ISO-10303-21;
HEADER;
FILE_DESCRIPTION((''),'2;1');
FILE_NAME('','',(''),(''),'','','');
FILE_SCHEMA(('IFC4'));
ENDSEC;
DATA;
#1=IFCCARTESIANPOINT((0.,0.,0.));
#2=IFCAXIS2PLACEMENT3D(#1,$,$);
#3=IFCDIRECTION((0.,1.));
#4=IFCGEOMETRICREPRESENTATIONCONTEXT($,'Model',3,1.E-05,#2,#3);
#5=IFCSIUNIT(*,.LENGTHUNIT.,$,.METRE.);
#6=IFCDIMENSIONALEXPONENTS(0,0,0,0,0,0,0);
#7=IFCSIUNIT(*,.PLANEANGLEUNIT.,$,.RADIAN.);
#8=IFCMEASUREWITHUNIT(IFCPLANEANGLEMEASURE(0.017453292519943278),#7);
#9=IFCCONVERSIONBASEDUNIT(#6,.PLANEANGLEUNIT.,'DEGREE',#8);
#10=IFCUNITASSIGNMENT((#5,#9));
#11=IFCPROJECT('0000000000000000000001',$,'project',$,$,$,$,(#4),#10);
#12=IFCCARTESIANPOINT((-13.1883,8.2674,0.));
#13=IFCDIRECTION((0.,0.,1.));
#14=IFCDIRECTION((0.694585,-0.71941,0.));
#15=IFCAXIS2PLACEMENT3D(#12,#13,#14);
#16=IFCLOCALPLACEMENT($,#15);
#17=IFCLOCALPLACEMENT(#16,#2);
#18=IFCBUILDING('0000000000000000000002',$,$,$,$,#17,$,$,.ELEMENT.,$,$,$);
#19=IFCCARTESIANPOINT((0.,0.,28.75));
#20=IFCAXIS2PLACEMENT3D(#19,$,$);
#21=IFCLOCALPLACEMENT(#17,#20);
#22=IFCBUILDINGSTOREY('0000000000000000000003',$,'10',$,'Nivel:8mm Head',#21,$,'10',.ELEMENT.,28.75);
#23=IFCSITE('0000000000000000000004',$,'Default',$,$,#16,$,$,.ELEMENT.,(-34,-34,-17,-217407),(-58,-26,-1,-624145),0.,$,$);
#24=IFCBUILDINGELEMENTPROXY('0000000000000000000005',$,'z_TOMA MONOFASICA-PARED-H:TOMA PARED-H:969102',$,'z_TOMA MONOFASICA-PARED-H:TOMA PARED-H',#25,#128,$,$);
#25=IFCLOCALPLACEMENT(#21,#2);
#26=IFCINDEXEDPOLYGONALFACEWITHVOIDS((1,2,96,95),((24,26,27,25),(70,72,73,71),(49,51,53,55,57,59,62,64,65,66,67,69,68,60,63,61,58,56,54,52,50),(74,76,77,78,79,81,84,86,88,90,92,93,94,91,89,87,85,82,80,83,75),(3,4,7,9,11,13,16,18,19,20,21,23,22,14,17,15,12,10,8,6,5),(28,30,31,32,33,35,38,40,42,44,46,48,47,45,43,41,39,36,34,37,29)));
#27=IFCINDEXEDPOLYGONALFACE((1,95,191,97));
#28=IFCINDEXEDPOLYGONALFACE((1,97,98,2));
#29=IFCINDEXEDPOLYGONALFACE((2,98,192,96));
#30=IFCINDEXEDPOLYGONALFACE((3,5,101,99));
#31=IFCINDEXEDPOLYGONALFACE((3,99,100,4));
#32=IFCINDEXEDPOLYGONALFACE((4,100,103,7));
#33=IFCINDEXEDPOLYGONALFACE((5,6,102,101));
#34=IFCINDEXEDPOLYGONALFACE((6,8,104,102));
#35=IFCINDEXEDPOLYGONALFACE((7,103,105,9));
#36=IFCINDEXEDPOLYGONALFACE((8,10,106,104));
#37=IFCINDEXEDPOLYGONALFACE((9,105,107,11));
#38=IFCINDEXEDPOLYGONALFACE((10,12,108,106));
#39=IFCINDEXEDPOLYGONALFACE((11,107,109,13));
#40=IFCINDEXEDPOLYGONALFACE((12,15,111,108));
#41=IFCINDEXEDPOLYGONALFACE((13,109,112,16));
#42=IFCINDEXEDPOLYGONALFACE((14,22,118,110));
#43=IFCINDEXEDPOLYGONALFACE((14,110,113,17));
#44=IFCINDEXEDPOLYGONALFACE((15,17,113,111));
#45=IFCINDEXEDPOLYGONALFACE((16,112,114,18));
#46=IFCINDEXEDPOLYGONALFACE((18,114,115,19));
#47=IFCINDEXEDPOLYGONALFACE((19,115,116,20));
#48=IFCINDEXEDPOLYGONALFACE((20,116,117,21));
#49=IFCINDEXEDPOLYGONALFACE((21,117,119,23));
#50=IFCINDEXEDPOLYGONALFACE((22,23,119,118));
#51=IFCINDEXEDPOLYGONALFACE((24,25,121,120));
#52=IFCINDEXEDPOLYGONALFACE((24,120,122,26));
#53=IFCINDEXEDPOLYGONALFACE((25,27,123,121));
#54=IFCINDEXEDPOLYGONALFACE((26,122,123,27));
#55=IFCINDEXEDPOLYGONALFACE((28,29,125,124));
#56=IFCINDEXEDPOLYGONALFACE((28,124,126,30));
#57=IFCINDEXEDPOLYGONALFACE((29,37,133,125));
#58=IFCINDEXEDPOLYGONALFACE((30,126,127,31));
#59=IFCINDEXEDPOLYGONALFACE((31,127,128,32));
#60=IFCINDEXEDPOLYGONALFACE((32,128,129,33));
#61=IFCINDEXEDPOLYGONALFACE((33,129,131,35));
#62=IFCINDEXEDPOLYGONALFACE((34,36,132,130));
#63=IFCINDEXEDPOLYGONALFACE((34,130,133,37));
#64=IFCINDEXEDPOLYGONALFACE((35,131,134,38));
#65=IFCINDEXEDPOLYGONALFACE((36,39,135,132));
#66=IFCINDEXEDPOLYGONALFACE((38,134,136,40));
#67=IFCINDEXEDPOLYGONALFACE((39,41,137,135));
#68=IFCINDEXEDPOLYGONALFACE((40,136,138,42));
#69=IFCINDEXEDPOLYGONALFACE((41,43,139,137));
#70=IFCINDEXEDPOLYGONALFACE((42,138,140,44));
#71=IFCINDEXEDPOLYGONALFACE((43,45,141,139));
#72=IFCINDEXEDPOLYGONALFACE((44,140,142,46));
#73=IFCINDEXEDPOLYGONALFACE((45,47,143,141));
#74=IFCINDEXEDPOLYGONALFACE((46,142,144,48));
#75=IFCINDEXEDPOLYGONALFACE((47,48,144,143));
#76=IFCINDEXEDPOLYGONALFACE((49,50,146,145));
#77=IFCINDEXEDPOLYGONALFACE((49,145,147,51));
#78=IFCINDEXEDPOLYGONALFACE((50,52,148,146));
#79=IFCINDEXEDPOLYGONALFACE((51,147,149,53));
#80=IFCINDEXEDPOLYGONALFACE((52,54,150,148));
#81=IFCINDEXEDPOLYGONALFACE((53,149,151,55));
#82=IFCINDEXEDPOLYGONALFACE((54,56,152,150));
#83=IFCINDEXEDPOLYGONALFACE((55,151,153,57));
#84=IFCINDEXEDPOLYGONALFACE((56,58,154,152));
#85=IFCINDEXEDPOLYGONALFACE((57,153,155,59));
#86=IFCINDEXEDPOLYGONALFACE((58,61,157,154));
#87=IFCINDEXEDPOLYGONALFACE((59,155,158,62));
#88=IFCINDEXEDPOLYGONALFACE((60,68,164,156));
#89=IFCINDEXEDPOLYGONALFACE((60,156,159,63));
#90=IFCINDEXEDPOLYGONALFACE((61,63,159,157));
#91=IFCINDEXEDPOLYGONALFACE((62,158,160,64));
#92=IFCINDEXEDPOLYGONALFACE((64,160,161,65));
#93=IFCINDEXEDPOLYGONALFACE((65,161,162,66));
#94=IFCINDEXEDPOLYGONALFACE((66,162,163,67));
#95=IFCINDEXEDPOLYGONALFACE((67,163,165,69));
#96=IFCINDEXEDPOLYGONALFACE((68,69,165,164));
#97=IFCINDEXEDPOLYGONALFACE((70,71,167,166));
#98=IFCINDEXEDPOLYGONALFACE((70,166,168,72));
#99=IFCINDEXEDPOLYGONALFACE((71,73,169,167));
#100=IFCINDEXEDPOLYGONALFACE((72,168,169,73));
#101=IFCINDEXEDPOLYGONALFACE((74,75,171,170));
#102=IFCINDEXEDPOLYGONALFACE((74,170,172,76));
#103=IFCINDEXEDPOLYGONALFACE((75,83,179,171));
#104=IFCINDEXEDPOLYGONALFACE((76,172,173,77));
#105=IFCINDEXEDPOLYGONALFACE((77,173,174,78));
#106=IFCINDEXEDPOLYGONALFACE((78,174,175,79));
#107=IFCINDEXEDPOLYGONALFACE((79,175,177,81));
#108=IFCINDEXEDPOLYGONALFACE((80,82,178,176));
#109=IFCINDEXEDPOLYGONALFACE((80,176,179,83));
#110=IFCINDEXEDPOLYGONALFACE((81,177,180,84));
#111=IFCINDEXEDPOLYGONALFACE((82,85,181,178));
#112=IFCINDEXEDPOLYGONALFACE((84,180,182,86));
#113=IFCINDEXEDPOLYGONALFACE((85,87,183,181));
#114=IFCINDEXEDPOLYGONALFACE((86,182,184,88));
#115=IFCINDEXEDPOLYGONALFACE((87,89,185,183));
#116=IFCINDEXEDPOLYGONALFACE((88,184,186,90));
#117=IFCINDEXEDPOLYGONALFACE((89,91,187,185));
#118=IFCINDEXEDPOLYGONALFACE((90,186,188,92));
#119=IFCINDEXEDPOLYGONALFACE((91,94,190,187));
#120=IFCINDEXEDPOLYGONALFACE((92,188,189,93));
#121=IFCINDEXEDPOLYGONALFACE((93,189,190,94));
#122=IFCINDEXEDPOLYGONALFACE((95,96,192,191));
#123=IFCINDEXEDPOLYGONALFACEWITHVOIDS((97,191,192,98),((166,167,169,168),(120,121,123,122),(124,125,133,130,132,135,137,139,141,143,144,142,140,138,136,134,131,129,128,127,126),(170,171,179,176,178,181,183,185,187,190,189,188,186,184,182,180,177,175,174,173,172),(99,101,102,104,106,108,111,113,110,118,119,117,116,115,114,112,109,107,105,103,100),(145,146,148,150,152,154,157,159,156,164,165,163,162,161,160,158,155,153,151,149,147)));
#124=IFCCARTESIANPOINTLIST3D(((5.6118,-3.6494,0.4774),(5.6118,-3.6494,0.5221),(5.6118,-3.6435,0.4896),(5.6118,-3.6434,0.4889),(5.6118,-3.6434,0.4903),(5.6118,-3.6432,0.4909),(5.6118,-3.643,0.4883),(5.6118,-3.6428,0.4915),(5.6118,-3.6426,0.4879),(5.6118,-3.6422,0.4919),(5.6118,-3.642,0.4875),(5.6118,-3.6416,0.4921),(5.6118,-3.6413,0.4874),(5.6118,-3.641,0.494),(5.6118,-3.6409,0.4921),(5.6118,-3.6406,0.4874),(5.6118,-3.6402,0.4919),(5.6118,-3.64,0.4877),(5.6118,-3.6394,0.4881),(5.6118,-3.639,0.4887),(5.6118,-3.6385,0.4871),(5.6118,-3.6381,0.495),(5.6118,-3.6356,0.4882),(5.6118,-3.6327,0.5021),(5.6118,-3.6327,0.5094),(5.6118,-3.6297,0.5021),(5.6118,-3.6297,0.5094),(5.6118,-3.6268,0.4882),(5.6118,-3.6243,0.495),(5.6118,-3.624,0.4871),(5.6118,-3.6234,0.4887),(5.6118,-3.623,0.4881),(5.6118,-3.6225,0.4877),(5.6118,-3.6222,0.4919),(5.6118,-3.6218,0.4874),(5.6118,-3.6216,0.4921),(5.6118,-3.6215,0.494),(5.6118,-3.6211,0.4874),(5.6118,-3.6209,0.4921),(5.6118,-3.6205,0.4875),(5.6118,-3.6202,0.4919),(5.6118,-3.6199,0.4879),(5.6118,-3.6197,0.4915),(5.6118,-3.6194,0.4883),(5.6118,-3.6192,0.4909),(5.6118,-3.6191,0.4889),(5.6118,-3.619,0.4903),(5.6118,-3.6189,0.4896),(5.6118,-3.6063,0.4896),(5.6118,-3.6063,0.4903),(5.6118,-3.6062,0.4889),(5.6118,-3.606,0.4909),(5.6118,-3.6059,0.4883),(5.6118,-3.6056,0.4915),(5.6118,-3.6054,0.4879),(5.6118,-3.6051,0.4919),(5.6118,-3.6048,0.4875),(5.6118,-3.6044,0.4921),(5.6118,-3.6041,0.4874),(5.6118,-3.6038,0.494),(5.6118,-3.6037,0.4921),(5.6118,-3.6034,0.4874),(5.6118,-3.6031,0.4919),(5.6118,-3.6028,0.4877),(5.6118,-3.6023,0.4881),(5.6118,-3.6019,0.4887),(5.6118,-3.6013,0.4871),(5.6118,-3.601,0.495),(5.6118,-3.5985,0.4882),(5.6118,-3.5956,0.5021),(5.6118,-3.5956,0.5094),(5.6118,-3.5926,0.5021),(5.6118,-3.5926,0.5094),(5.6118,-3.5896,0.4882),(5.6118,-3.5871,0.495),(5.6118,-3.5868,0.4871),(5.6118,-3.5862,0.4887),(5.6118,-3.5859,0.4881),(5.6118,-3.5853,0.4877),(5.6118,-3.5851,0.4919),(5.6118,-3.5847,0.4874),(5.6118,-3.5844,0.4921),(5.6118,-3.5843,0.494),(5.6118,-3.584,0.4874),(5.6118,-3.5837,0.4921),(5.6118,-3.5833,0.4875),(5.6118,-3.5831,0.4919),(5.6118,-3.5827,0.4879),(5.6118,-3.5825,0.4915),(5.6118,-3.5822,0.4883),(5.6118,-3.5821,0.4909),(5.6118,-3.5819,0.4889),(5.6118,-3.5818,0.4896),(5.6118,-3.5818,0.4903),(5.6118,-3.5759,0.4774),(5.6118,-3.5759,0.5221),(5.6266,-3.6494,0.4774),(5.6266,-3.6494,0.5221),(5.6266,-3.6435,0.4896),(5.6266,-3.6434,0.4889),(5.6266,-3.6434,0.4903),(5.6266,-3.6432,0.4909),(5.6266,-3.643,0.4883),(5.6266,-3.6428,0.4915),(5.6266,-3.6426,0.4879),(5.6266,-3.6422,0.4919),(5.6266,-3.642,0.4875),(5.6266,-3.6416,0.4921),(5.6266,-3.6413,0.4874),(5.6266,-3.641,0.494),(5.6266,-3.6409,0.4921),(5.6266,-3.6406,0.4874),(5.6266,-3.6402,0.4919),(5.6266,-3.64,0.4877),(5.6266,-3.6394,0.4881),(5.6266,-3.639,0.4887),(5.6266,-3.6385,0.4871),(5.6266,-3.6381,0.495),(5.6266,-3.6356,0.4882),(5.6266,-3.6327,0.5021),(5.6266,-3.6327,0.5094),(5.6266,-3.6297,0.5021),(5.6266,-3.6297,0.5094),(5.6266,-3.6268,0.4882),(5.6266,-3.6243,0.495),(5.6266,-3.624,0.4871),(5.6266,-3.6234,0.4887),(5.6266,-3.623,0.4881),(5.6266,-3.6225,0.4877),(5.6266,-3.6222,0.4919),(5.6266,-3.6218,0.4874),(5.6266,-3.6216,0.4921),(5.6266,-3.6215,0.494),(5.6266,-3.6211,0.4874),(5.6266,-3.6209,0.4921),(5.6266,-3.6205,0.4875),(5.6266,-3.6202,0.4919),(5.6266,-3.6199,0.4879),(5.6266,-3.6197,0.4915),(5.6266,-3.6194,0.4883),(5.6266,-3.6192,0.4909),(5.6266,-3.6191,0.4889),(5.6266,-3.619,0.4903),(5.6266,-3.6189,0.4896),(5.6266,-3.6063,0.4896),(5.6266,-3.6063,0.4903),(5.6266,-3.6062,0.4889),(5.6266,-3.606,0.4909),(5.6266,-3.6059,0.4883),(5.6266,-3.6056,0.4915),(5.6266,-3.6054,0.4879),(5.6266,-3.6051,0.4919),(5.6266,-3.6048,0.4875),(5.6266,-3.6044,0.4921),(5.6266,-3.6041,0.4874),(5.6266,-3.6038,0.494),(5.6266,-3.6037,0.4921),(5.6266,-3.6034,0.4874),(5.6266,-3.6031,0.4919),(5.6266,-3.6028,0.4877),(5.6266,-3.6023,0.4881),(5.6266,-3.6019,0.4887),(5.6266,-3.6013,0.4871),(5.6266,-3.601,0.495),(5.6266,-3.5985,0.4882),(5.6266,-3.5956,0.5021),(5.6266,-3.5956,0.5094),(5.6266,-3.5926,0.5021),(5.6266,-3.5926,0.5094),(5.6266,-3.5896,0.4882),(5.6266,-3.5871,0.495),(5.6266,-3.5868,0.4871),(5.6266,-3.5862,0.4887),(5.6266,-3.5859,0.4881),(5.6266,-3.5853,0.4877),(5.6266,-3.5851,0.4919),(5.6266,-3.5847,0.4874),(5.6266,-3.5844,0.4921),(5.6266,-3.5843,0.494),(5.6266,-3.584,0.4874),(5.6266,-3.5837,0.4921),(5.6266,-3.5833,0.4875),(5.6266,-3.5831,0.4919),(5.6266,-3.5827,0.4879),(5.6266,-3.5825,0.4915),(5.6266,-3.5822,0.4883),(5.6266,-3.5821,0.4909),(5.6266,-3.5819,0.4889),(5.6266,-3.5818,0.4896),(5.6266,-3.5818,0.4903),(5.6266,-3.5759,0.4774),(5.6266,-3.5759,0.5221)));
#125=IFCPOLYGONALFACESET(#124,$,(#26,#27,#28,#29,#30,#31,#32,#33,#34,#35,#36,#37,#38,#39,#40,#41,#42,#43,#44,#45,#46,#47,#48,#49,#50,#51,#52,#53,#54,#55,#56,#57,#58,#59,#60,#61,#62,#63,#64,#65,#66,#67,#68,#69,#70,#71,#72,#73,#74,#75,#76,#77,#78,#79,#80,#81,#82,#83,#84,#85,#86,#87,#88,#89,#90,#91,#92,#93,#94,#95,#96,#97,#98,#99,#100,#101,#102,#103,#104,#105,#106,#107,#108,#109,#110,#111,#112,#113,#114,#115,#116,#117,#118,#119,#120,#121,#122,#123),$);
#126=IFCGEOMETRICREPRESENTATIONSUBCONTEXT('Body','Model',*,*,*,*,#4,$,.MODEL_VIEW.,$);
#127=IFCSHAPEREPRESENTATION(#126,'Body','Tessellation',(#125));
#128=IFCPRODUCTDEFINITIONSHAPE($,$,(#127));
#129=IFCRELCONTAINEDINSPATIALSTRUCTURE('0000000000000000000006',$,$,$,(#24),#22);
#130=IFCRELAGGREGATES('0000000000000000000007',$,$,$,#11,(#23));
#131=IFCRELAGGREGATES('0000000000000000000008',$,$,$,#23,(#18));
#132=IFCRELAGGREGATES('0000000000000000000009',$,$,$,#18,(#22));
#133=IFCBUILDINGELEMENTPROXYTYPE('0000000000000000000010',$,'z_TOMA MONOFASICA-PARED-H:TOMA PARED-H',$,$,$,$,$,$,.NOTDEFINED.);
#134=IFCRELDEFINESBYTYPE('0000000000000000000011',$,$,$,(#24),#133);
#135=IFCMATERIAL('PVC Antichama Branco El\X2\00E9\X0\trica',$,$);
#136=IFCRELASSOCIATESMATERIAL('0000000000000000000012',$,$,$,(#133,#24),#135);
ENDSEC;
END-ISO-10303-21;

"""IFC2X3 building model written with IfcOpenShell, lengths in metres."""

from ifc_helpers import new_model, entity, si_unit, converted_unit, direction, frame, frame_2d, origin, place, context, subcontext, project, spatial, polyline, circle_curve, parameter, trimmed, segment, composite_curve, outline, extrude, source, transform, mapped, material, type_object, type_shapes, element, save


model = new_model("IFC2X3")

# Units and contexts
model_context = context("Model", 3, precision=1e-05, world=origin(), true_north=direction((0.0, 1.0)))
body_context = subcontext(model_context, "Body", "Model", "MODEL_VIEW")
ifc_project = project(units=[si_unit("LENGTHUNIT", "METRE"), converted_unit("PLANEANGLEUNIT", "DEGREE", entity("IfcPlaneAngleMeasure", 0.017453292519943278), si_unit("PLANEANGLEUNIT", "RADIAN"), dimensions=[0, 0, 0, 0, 0, 0, 0])], contexts=[model_context])

# Site, building, storey
site_placement = place(None, frame((-13.1883, 8.2674, 0.0), z_axis=(0.0, 0.0, 1.0), x_axis=(0.694585, -0.71941, 0.0)))
site = spatial("IfcSite", under=ifc_project, at=site_placement, Name="Default", CompositionType="ELEMENT", RefLatitude=(-34, -34, -17, -217407), RefLongitude=(-58, -26, -1, -624145), RefElevation=0.0)
building_placement = place(site_placement, origin())
building = spatial("IfcBuilding", under=site, at=building_placement, CompositionType="ELEMENT")
storey_placement = place(building_placement, frame((0.0, 0.0, 28.75)))
storey = spatial("IfcBuildingStorey", under=building, at=storey_placement, Name="10", ObjectType="Nivel:8mm Head", LongName="10", CompositionType="ELEMENT", Elevation=28.75)

# Building element proxy
ifc_material_1 = material(Name="PVC Antichama Branco Elétrica")
building_element_proxy_type_1 = type_object("IfcBuildingElementProxyType", Name="z_TOMA MONOFASICA-PARED-H:TOMA PARED-H", PredefinedType="NOTDEFINED", material=ifc_material_1)
shared_shape_1 = source(origin(), body_context, "Body", "SweptSolid", [
    extrude(outline(polyline([(-0.0368, -0.0223), (0.0368, -0.0223), (0.0368, 0.0223), (-0.0368, 0.0223), (-0.0368, -0.0223)]), holes=[composite_curve([segment(polyline([(0.0141, 0.0115), (0.0116, 0.0047)]), True, "CONTINUOUS"), segment(polyline([(0.0116, 0.0047), (0.0088, 0.0057)]), True, "CONTINUOUS"), segment(polyline([(0.0088, 0.0057), (0.0096, 0.0078)]), True, "CONTINUOUS"), segment(trimmed(circle_curve(frame_2d((0.0087, 0.0099), x_axis=(1.0, 0.0)), 0.0024), [parameter(27.118901)], [parameter(292.881099)], True, "PARAMETER"), False, "CONTINUOUS"), segment(polyline([(0.0108, 0.011), (0.0113, 0.0126)]), True, "CONTINUOUS"), segment(polyline([(0.0113, 0.0126), (0.0141, 0.0115)]), True, "CONTINUOUS")], self_intersect=False), composite_curve([segment(polyline([(0.0255, 0.0047), (0.023, 0.0115)]), True, "CONTINUOUS"), segment(polyline([(0.023, 0.0115), (0.0258, 0.0126)]), True, "CONTINUOUS"), segment(polyline([(0.0258, 0.0126), (0.0264, 0.011)]), True, "CONTINUOUS"), segment(trimmed(circle_curve(frame_2d((0.0285, 0.0099), x_axis=(1.0, 0.0)), 0.0024), [parameter(247.118901)], [parameter(152.881099)], True, "PARAMETER"), False, "CONTINUOUS"), segment(polyline([(0.0276, 0.0078), (0.0283, 0.0057)]), True, "CONTINUOUS"), segment(polyline([(0.0283, 0.0057), (0.0255, 0.0047)]), True, "CONTINUOUS")], self_intersect=False), polyline([(0.0201, -0.0024), (0.0201, -0.0097), (0.0171, -0.0097), (0.0171, -0.0024), (0.0201, -0.0024)]), composite_curve([segment(polyline([(-0.0141, 0.0115), (-0.0113, 0.0126)]), True, "CONTINUOUS"), segment(polyline([(-0.0113, 0.0126), (-0.0108, 0.011)]), True, "CONTINUOUS"), segment(trimmed(circle_curve(frame_2d((-0.0087, 0.0099), x_axis=(1.0, 0.0)), 0.0024), [parameter(247.118901)], [parameter(152.881099)], True, "PARAMETER"), False, "CONTINUOUS"), segment(polyline([(-0.0096, 0.0078), (-0.0088, 0.0057)]), True, "CONTINUOUS"), segment(polyline([(-0.0088, 0.0057), (-0.0116, 0.0047)]), True, "CONTINUOUS"), segment(polyline([(-0.0116, 0.0047), (-0.0141, 0.0115)]), True, "CONTINUOUS")], self_intersect=False), composite_curve([segment(polyline([(-0.0255, 0.0047), (-0.0283, 0.0057)]), True, "CONTINUOUS"), segment(polyline([(-0.0283, 0.0057), (-0.0276, 0.0078)]), True, "CONTINUOUS"), segment(trimmed(circle_curve(frame_2d((-0.0285, 0.0099), x_axis=(1.0, 0.0)), 0.0024), [parameter(27.118901)], [parameter(292.881099)], True, "PARAMETER"), False, "CONTINUOUS"), segment(polyline([(-0.0264, 0.011), (-0.0258, 0.0126)]), True, "CONTINUOUS"), segment(polyline([(-0.0258, 0.0126), (-0.023, 0.0115)]), True, "CONTINUOUS"), segment(polyline([(-0.023, 0.0115), (-0.0255, 0.0047)]), True, "CONTINUOUS")], self_intersect=False), polyline([(-0.0201, -0.0024), (-0.0171, -0.0024), (-0.0171, -0.0097), (-0.0201, -0.0097), (-0.0201, -0.0024)])]), frame((0.0, -0.005, 0.0223), z_axis=(0.0, 1.0, 0.0), x_axis=(1.0, 0.0, 0.0)), (0.0, 0.0, 1.0), 0.0148),
])
type_shapes(building_element_proxy_type_1, [shared_shape_1])
proxy_1_placement = place(storey_placement, frame((5.6216, -3.6126, 0.4774), z_axis=(0.0, 0.0, 1.0), x_axis=(0.0, 1.0, 0.0)))
element("IfcBuildingElementProxy", 1, at=proxy_1_placement, inside=storey, type_object=building_element_proxy_type_1, material=ifc_material_1, Name="z_TOMA MONOFASICA-PARED-H:TOMA PARED-H:969102", ObjectType="z_TOMA MONOFASICA-PARED-H:TOMA PARED-H", context=body_context, shape_type="MappedRepresentation", body=[
    mapped(shared_shape_1, transform((0.0, 0.0, 0.0), scale=1.0)),
])

save(model, "model.ifc")
